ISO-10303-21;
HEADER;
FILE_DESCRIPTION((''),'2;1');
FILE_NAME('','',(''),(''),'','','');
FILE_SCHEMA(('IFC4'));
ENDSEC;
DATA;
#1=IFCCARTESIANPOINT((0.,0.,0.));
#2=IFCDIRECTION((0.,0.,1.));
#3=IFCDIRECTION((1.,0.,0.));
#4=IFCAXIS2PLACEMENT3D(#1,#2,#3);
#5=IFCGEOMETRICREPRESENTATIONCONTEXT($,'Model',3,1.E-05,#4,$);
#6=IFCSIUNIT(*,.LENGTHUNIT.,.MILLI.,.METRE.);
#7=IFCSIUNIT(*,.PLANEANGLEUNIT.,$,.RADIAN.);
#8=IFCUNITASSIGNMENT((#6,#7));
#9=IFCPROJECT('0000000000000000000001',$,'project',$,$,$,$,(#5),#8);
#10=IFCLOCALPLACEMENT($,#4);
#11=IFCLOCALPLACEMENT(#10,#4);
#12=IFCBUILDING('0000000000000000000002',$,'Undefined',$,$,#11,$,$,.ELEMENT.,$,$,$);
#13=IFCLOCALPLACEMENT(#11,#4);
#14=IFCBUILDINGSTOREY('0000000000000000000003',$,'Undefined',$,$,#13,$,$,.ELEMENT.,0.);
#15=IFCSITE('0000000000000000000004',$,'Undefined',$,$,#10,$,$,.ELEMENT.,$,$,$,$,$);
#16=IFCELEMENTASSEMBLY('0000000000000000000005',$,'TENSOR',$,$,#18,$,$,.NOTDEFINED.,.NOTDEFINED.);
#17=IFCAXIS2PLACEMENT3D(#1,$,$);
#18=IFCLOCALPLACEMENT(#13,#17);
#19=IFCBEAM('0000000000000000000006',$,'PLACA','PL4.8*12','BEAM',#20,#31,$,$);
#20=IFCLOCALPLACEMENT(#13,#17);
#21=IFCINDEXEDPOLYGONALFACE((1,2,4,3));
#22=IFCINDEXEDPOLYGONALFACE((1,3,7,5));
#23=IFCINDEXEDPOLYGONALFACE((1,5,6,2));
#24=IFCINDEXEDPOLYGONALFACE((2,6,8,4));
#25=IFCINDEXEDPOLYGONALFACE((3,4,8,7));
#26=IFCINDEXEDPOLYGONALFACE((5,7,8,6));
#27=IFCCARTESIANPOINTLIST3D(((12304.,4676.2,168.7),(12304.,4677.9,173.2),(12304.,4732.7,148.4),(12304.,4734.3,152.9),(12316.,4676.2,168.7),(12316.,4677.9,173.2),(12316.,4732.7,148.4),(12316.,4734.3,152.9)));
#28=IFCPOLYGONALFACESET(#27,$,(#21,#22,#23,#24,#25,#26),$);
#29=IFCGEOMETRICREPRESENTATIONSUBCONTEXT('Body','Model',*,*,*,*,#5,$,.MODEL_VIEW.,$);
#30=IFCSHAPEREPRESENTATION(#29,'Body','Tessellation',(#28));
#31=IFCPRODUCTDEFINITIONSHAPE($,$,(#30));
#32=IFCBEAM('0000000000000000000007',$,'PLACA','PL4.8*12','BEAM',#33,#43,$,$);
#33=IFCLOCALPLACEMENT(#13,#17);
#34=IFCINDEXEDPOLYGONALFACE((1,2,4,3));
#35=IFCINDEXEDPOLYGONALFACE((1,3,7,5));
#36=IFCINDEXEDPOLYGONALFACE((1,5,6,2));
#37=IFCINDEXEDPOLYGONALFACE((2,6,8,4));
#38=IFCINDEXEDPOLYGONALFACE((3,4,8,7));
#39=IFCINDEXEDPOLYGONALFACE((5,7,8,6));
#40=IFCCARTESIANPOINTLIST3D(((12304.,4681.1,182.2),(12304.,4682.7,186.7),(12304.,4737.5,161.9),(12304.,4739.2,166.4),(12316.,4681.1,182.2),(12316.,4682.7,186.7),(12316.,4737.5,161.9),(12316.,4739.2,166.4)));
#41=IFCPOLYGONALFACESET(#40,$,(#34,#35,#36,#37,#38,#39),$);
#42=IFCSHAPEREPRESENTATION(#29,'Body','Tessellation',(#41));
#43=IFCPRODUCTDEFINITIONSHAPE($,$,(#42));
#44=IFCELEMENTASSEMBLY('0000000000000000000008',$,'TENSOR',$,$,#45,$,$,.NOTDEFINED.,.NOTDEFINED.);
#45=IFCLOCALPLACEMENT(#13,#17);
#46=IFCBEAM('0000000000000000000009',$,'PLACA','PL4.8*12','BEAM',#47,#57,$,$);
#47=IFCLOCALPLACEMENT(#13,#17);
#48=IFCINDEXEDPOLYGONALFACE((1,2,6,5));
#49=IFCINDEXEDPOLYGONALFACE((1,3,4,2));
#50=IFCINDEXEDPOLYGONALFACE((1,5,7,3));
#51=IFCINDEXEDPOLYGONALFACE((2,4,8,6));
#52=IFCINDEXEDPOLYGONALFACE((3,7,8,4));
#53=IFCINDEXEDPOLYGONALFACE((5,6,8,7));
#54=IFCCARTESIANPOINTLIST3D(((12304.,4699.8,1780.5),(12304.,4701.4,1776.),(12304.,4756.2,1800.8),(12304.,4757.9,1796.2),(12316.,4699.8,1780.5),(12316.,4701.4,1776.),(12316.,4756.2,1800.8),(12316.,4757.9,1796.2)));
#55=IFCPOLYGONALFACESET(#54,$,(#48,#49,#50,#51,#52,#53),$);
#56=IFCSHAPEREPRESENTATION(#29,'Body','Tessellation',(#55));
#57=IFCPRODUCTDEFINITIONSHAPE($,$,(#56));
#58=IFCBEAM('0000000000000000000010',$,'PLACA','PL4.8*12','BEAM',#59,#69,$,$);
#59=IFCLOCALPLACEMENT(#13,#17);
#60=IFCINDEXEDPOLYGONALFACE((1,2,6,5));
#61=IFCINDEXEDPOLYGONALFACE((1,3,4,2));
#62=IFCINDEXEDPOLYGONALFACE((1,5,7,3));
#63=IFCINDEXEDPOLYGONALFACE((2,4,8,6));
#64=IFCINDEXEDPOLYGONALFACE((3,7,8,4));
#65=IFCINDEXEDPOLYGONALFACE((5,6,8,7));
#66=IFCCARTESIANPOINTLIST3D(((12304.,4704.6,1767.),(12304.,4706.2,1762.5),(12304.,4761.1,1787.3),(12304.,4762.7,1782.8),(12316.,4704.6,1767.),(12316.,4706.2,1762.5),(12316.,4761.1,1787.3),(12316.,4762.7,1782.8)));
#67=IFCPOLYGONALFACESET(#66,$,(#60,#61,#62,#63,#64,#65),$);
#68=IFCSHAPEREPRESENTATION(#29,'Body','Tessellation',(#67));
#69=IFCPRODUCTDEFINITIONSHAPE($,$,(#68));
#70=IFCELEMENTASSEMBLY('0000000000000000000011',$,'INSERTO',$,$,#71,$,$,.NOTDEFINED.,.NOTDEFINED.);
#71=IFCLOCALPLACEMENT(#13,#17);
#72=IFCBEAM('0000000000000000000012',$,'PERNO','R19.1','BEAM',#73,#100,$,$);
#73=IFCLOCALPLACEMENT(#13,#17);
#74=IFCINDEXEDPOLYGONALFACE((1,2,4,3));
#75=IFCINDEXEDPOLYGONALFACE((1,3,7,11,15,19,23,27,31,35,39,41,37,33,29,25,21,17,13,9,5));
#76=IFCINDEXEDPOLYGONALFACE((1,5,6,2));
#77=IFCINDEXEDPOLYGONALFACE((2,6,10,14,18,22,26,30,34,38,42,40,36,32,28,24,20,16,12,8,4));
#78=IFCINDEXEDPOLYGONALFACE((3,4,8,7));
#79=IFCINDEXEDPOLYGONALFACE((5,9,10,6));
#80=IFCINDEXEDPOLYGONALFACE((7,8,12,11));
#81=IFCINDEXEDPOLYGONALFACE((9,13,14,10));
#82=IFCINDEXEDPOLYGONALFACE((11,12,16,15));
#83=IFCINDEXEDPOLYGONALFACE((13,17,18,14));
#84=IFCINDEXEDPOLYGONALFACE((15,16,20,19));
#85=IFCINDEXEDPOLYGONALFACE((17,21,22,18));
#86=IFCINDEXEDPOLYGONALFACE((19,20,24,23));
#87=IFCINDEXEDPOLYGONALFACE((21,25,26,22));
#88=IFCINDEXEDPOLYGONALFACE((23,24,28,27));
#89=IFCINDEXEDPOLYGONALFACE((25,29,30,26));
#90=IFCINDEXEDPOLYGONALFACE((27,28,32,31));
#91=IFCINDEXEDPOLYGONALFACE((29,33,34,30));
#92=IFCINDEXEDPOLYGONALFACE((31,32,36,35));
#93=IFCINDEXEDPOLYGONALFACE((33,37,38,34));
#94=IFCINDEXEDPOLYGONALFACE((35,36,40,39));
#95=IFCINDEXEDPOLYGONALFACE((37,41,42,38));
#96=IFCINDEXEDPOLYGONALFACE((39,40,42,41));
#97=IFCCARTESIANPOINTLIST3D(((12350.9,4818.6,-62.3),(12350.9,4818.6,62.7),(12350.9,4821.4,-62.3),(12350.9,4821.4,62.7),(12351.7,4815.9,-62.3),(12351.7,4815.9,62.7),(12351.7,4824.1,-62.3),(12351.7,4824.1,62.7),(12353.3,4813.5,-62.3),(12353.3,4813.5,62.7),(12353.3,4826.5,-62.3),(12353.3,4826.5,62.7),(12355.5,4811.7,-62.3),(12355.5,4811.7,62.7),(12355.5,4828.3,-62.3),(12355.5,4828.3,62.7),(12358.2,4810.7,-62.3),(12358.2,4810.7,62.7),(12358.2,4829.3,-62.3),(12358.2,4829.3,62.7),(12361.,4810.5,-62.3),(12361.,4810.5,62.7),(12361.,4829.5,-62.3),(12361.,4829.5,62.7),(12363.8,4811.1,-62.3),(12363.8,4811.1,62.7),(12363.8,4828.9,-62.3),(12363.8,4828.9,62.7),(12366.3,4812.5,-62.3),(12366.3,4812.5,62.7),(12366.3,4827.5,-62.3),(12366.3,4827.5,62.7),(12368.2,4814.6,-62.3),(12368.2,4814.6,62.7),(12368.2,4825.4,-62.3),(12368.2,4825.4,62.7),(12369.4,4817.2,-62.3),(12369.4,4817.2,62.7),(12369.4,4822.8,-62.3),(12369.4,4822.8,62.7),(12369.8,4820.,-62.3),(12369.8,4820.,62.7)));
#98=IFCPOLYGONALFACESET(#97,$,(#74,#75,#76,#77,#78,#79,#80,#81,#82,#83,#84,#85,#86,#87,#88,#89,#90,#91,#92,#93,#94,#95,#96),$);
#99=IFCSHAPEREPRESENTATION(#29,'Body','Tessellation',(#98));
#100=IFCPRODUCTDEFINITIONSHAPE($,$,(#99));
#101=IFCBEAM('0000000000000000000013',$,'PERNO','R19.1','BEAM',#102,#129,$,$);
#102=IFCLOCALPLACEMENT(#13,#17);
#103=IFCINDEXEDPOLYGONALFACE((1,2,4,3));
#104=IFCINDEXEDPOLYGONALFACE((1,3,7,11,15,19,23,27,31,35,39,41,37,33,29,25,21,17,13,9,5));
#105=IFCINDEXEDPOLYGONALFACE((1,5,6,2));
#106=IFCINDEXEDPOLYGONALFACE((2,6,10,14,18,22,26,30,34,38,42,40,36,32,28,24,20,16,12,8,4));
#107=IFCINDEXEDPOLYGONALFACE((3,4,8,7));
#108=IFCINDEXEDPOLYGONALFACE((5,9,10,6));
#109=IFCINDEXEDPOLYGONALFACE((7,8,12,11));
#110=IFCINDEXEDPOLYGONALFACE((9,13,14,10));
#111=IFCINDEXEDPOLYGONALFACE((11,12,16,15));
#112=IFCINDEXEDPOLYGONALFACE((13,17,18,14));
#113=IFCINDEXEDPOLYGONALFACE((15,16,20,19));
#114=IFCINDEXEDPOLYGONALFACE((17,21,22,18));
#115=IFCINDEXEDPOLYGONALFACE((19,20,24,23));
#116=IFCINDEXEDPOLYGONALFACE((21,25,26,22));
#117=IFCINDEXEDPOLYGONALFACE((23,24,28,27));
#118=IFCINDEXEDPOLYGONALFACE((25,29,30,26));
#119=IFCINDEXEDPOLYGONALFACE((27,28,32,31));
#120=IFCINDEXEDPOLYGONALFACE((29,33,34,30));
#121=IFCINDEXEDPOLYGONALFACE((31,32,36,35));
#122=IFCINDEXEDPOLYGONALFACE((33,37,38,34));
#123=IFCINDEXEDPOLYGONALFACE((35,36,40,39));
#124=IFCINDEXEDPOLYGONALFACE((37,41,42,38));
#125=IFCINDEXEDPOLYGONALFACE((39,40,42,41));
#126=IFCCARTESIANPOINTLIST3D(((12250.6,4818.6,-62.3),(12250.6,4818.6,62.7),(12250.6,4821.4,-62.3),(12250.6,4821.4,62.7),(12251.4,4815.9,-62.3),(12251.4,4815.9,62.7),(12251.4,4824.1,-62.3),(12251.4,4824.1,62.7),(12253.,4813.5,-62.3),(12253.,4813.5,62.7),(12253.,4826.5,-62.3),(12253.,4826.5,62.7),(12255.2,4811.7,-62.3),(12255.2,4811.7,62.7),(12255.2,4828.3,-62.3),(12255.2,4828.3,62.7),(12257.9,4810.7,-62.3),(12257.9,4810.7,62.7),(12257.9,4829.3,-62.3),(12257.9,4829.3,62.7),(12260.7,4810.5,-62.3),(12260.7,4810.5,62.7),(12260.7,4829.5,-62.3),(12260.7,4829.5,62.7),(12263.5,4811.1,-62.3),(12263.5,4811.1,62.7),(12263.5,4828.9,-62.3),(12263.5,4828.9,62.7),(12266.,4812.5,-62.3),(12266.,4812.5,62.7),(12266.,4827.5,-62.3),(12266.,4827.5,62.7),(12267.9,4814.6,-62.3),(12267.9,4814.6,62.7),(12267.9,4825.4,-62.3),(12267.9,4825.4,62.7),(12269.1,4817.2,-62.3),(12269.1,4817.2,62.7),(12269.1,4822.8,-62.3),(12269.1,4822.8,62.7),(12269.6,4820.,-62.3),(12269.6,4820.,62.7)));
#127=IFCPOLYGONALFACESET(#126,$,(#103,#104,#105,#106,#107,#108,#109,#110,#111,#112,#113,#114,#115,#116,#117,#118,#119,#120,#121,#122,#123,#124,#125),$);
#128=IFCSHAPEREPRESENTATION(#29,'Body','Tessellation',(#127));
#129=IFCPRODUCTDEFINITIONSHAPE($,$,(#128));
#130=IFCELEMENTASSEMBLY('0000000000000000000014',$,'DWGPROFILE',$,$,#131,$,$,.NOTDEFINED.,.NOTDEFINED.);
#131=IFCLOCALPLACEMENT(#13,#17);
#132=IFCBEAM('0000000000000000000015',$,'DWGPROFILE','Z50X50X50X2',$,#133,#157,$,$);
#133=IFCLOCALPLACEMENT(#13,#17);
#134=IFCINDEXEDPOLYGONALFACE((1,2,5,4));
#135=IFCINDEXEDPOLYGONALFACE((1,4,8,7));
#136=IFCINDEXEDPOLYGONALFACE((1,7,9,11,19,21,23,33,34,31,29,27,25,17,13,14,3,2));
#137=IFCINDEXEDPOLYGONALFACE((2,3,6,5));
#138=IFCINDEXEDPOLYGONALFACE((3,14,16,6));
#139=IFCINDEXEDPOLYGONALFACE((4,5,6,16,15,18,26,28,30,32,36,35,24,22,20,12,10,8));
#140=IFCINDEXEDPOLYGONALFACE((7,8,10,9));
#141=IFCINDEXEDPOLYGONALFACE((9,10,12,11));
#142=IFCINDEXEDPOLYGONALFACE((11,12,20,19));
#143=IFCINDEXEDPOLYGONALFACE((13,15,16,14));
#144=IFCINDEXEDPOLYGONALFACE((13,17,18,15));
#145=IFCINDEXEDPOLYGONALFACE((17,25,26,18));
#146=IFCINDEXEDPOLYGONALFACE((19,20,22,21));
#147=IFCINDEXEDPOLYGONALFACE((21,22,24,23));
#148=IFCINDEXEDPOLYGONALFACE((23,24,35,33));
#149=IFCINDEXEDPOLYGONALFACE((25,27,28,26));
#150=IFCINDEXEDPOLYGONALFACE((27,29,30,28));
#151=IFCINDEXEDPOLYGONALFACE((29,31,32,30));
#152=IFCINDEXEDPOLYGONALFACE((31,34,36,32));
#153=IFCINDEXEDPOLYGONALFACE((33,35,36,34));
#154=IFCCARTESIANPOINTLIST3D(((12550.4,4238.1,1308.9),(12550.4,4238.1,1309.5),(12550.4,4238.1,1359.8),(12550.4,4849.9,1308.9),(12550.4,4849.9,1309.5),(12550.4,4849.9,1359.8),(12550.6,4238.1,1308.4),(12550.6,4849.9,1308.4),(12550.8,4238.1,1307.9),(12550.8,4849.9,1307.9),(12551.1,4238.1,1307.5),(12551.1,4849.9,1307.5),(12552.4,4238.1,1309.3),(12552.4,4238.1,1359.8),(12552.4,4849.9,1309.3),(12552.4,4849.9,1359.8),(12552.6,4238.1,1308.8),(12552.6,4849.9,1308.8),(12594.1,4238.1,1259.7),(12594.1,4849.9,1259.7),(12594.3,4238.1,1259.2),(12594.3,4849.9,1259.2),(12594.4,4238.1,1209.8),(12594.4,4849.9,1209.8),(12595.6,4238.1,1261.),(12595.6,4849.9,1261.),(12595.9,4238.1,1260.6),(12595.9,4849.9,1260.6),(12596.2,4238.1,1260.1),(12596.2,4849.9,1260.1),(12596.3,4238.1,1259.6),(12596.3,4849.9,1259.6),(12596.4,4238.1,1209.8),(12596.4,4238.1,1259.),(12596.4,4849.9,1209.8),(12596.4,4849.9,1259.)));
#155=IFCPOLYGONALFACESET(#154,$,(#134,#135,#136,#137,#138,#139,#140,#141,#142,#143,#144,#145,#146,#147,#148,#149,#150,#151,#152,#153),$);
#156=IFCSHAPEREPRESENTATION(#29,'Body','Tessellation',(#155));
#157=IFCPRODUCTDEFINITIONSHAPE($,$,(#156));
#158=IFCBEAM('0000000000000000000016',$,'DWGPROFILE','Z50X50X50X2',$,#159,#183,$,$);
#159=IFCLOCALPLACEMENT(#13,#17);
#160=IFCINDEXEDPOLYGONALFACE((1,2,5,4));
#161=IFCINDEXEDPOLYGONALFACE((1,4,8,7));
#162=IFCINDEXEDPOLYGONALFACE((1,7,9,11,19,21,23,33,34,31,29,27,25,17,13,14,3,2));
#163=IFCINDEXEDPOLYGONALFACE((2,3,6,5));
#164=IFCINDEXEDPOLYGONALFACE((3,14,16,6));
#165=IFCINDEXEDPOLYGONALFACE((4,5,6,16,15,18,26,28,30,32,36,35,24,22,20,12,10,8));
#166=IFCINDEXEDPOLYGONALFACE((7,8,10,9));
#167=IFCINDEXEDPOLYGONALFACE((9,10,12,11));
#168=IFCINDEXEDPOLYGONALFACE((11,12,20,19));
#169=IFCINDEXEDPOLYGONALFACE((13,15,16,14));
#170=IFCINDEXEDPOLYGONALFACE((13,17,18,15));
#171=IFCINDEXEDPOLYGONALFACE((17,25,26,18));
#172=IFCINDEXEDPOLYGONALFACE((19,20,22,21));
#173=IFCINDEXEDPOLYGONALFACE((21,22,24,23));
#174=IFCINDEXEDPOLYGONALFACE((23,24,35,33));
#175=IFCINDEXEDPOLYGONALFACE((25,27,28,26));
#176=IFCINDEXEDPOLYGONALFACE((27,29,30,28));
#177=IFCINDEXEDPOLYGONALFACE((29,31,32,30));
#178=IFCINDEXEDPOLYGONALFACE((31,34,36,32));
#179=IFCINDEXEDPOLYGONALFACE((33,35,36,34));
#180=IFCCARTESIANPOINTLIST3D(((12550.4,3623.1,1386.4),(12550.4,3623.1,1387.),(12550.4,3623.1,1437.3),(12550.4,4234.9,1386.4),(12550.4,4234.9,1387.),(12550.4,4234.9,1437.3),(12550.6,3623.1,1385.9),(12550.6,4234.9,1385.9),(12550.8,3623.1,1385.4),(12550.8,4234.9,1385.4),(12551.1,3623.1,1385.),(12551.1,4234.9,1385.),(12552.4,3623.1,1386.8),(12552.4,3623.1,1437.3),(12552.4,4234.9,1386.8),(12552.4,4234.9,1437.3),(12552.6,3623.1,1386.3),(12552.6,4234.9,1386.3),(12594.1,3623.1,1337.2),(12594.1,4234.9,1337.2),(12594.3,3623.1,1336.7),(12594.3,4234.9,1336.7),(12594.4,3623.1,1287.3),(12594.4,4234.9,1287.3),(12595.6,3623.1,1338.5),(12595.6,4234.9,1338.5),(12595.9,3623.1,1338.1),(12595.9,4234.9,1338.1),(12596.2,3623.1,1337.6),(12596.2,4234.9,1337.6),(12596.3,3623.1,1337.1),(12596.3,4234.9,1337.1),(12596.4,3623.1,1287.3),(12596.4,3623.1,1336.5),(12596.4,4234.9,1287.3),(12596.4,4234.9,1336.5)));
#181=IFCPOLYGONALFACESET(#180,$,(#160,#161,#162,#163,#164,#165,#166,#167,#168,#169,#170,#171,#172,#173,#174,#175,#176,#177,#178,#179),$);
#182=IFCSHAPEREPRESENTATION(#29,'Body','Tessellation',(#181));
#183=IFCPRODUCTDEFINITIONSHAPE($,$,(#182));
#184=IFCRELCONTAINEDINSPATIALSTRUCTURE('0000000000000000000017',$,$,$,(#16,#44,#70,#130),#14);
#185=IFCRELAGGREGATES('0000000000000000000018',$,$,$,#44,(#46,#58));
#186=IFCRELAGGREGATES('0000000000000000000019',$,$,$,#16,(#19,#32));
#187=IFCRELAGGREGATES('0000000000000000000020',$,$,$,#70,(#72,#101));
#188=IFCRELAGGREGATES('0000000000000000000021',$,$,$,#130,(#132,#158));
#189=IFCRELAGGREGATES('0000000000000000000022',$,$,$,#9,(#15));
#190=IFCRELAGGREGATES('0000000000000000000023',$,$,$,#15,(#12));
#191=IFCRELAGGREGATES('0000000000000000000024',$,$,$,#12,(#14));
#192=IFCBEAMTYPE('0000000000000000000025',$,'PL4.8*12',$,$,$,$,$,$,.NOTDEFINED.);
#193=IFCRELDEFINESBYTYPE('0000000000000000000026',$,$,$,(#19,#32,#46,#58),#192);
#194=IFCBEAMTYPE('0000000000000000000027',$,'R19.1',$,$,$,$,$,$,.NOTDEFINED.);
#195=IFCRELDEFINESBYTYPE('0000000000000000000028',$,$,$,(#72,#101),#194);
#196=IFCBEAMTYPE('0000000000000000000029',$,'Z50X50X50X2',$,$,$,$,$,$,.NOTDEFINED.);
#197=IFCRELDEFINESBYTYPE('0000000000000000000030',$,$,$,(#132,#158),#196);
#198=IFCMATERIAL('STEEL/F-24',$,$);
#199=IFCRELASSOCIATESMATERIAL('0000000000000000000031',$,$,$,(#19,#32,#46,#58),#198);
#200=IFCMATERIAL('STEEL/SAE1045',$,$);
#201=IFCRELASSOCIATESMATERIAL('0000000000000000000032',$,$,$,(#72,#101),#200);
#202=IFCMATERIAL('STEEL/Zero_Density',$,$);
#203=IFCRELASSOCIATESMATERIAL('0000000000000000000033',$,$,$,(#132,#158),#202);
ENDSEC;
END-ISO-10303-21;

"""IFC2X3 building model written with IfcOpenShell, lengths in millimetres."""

from ifc_helpers import new_model, si_unit, frame, origin_with_axes, origin_2d_with_axis, place, context, subcontext, project, spatial, polyline, rectangle, circle, outline, extrude, material, type_object, element, aggregate, save


model = new_model("IFC2X3")

# Units and contexts
model_context = context("Model", 3, precision=1e-05, world=origin_with_axes())
body_context = subcontext(model_context, "Body", "Model", "MODEL_VIEW")
ifc_project = project(units=[si_unit("LENGTHUNIT", "METRE", prefix="MILLI"), si_unit("PLANEANGLEUNIT", "RADIAN")], contexts=[model_context])

# Site, building, storey
site_placement = place(None, origin_with_axes())
site = spatial("IfcSite", under=ifc_project, at=site_placement, Name="Undefined", CompositionType="ELEMENT")
building_placement = place(site_placement, origin_with_axes())
building = spatial("IfcBuilding", under=site, at=building_placement, Name="Undefined", CompositionType="ELEMENT")
storey_placement = place(building_placement, origin_with_axes())
storey = spatial("IfcBuildingStorey", under=building, at=storey_placement, Name="Undefined", CompositionType="ELEMENT", Elevation=0.0)

# Element assemblies, beams
assembly_1_placement = place(storey_placement, origin_with_axes())
assembly_1 = element("IfcElementAssembly", 1, at=assembly_1_placement, inside=storey, Name="TENSOR", AssemblyPlace="NOTDEFINED", PredefinedType="NOTDEFINED")
ifc_material_1 = material(Name="STEEL/F-24")
beam_type_1 = type_object("IfcBeamType", Name="PL4.8*12", PredefinedType="NOTDEFINED")
beam_1_placement = place(assembly_1_placement, frame((12310.0, 4733.5, 150.7), z_axis=(-1.0, 0.0, 0.0), x_axis=(0.0, -0.941136, 0.338027)))
beam_1 = element("IfcBeam", 2, at=beam_1_placement, type_object=beam_type_1, material=ifc_material_1, Name="PLACA", Description="PL4.8*12", ObjectType="BEAM", context=body_context, shape_type="SweptSolid", body=[
    extrude(rectangle(XDim=4.8, YDim=12.0, at=origin_2d_with_axis()), frame((60.0, 0.0, 0.0), z_axis=(-1.0, 0.0, 0.0), x_axis=(0.0, -1.0, 0.0)), (0.0, 0.0, 1.0), 60.0),
])
beam_2_placement = place(assembly_1_placement, frame((12310.0, 4738.3, 164.1), z_axis=(-1.0, 0.0, 0.0), x_axis=(0.0, -0.941136, 0.338027)))
beam_2 = element("IfcBeam", 3, at=beam_2_placement, type_object=beam_type_1, material=ifc_material_1, Name="PLACA", Description="PL4.8*12", ObjectType="BEAM", context=body_context, shape_type="SweptSolid", body=[
    extrude(rectangle(XDim=4.8, YDim=12.0, at=origin_2d_with_axis()), frame((60.0, 0.0, 0.0), z_axis=(-1.0, 0.0, 0.0), x_axis=(0.0, -1.0, 0.0)), (0.0, 0.0, 1.0), 60.0),
])
assembly_2_placement = place(storey_placement, origin_with_axes())
assembly_2 = element("IfcElementAssembly", 4, at=assembly_2_placement, inside=storey, Name="TENSOR", AssemblyPlace="NOTDEFINED", PredefinedType="NOTDEFINED")
beam_3_placement = place(assembly_2_placement, frame((12310.0, 4757.0, 1798.5), z_axis=(1.0, 0.0, 0.0), x_axis=(0.0, -0.941136, -0.338027)))
beam_3 = element("IfcBeam", 5, at=beam_3_placement, type_object=beam_type_1, material=ifc_material_1, Name="PLACA", Description="PL4.8*12", ObjectType="BEAM", context=body_context, shape_type="SweptSolid", body=[
    extrude(rectangle(XDim=4.8, YDim=12.0, at=origin_2d_with_axis()), frame((60.0, 0.0, 0.0), z_axis=(-1.0, 0.0, 0.0), x_axis=(0.0, -1.0, 0.0)), (0.0, 0.0, 1.0), 60.0),
])
beam_4_placement = place(assembly_2_placement, frame((12310.0, 4761.9, 1785.0), z_axis=(1.0, 0.0, 0.0), x_axis=(0.0, -0.941136, -0.338027)))
beam_4 = element("IfcBeam", 6, at=beam_4_placement, type_object=beam_type_1, material=ifc_material_1, Name="PLACA", Description="PL4.8*12", ObjectType="BEAM", context=body_context, shape_type="SweptSolid", body=[
    extrude(rectangle(XDim=4.8, YDim=12.0, at=origin_2d_with_axis()), frame((60.0, 0.0, 0.0), z_axis=(-1.0, 0.0, 0.0), x_axis=(0.0, -1.0, 0.0)), (0.0, 0.0, 1.0), 60.0),
])

aggregate(assembly_2, [beam_3, beam_4])
aggregate(assembly_1, [beam_1, beam_2])

# Element assembly, beams
assembly_3_placement = place(storey_placement, origin_with_axes())
assembly_3 = element("IfcElementAssembly", 7, at=assembly_3_placement, inside=storey, Name="INSERTO", AssemblyPlace="NOTDEFINED", PredefinedType="NOTDEFINED")
ifc_material_2 = material(Name="STEEL/SAE1045")
beam_type_2 = type_object("IfcBeamType", Name="R19.1", PredefinedType="NOTDEFINED")
beam_5_placement = place(assembly_3_placement, frame((12360.3, 4820.0, -62.3), z_axis=(0.0, -1.0, 0.0), x_axis=(0.0, 0.0, 1.0)))
beam_5 = element("IfcBeam", 8, at=beam_5_placement, type_object=beam_type_2, material=ifc_material_2, Name="PERNO", Description="R19.1", ObjectType="BEAM", context=body_context, shape_type="SweptSolid", body=[
    extrude(circle(Radius=9.6, at=origin_2d_with_axis()), frame((125.0, 0.0, 0.0), z_axis=(-1.0, 0.0, 0.0), x_axis=(0.0, -1.0, 0.0)), (0.0, 0.0, 1.0), 125.0),
])
beam_6_placement = place(assembly_3_placement, frame((12260.0, 4820.0, -62.3), z_axis=(0.0, -1.0, 0.0), x_axis=(0.0, 0.0, 1.0)))
beam_6 = element("IfcBeam", 9, at=beam_6_placement, type_object=beam_type_2, material=ifc_material_2, Name="PERNO", Description="R19.1", ObjectType="BEAM", context=body_context, shape_type="SweptSolid", body=[
    extrude(circle(Radius=9.6, at=origin_2d_with_axis()), frame((125.0, 0.0, 0.0), z_axis=(-1.0, 0.0, 0.0), x_axis=(0.0, -1.0, 0.0)), (0.0, 0.0, 1.0), 125.0),
])
aggregate(assembly_3, [beam_5, beam_6])

# Element assembly, beams
assembly_4_placement = place(storey_placement, origin_with_axes())
assembly_4 = element("IfcElementAssembly", 10, at=assembly_4_placement, inside=storey, Name="DWGPROFILE", AssemblyPlace="NOTDEFINED", PredefinedType="NOTDEFINED")
ifc_material_3 = material(Name="STEEL/Zero_Density")
beam_type_3 = type_object("IfcBeamType", Name="Z50X50X50X2", PredefinedType="NOTDEFINED")
beam_7_placement = place(assembly_4_placement, frame((12573.4, 4238.1, 1284.8), z_axis=(0.0, 0.0, 1.0), x_axis=(0.0, 1.0, 0.0)))
beam_7 = element("IfcBeam", 11, at=beam_7_placement, type_object=beam_type_3, material=ifc_material_3, Name="DWGPROFILE", Description="Z50X50X50X2", context=body_context, shape_type="SweptSolid", body=[
    extrude(outline(polyline([(-22.9, 24.1), (-23.0, 24.7), (-23.0, 75.0), (-21.0, 75.0), (-21.0, 24.5), (-20.7, 24.0), (22.2, -23.8), (22.6, -24.2), (22.8, -24.7), (22.9, -25.2), (23.0, -25.8), (23.0, -75.0), (21.0, -75.0), (21.0, -25.6), (20.7, -25.1), (-22.2, 22.6), (-22.6, 23.1), (-22.8, 23.6), (-22.9, 24.1)])), frame((611.8, 0.0, 0.0), z_axis=(-1.0, 0.0, 0.0), x_axis=(0.0, -1.0, 0.0)), (0.0, 0.0, 1.0), 611.8),
])
beam_8_placement = place(assembly_4_placement, frame((12573.4, 3623.1, 1362.3), z_axis=(0.0, 0.0, 1.0), x_axis=(0.0, 1.0, 0.0)))
beam_8 = element("IfcBeam", 12, at=beam_8_placement, type_object=beam_type_3, material=ifc_material_3, Name="DWGPROFILE", Description="Z50X50X50X2", context=body_context, shape_type="SweptSolid", body=[
    extrude(outline(polyline([(-22.9, 24.1), (-23.0, 24.7), (-23.0, 75.0), (-21.0, 75.0), (-21.0, 24.5), (-20.7, 24.0), (22.2, -23.8), (22.6, -24.2), (22.8, -24.7), (22.9, -25.2), (23.0, -25.8), (23.0, -75.0), (21.0, -75.0), (21.0, -25.6), (20.7, -25.1), (-22.2, 22.6), (-22.6, 23.1), (-22.8, 23.6), (-22.9, 24.1)])), frame((611.8, 0.0, 0.0), z_axis=(-1.0, 0.0, 0.0), x_axis=(0.0, -1.0, 0.0)), (0.0, 0.0, 1.0), 611.8),
])
aggregate(assembly_4, [beam_7, beam_8])

save(model, "model.ifc")
